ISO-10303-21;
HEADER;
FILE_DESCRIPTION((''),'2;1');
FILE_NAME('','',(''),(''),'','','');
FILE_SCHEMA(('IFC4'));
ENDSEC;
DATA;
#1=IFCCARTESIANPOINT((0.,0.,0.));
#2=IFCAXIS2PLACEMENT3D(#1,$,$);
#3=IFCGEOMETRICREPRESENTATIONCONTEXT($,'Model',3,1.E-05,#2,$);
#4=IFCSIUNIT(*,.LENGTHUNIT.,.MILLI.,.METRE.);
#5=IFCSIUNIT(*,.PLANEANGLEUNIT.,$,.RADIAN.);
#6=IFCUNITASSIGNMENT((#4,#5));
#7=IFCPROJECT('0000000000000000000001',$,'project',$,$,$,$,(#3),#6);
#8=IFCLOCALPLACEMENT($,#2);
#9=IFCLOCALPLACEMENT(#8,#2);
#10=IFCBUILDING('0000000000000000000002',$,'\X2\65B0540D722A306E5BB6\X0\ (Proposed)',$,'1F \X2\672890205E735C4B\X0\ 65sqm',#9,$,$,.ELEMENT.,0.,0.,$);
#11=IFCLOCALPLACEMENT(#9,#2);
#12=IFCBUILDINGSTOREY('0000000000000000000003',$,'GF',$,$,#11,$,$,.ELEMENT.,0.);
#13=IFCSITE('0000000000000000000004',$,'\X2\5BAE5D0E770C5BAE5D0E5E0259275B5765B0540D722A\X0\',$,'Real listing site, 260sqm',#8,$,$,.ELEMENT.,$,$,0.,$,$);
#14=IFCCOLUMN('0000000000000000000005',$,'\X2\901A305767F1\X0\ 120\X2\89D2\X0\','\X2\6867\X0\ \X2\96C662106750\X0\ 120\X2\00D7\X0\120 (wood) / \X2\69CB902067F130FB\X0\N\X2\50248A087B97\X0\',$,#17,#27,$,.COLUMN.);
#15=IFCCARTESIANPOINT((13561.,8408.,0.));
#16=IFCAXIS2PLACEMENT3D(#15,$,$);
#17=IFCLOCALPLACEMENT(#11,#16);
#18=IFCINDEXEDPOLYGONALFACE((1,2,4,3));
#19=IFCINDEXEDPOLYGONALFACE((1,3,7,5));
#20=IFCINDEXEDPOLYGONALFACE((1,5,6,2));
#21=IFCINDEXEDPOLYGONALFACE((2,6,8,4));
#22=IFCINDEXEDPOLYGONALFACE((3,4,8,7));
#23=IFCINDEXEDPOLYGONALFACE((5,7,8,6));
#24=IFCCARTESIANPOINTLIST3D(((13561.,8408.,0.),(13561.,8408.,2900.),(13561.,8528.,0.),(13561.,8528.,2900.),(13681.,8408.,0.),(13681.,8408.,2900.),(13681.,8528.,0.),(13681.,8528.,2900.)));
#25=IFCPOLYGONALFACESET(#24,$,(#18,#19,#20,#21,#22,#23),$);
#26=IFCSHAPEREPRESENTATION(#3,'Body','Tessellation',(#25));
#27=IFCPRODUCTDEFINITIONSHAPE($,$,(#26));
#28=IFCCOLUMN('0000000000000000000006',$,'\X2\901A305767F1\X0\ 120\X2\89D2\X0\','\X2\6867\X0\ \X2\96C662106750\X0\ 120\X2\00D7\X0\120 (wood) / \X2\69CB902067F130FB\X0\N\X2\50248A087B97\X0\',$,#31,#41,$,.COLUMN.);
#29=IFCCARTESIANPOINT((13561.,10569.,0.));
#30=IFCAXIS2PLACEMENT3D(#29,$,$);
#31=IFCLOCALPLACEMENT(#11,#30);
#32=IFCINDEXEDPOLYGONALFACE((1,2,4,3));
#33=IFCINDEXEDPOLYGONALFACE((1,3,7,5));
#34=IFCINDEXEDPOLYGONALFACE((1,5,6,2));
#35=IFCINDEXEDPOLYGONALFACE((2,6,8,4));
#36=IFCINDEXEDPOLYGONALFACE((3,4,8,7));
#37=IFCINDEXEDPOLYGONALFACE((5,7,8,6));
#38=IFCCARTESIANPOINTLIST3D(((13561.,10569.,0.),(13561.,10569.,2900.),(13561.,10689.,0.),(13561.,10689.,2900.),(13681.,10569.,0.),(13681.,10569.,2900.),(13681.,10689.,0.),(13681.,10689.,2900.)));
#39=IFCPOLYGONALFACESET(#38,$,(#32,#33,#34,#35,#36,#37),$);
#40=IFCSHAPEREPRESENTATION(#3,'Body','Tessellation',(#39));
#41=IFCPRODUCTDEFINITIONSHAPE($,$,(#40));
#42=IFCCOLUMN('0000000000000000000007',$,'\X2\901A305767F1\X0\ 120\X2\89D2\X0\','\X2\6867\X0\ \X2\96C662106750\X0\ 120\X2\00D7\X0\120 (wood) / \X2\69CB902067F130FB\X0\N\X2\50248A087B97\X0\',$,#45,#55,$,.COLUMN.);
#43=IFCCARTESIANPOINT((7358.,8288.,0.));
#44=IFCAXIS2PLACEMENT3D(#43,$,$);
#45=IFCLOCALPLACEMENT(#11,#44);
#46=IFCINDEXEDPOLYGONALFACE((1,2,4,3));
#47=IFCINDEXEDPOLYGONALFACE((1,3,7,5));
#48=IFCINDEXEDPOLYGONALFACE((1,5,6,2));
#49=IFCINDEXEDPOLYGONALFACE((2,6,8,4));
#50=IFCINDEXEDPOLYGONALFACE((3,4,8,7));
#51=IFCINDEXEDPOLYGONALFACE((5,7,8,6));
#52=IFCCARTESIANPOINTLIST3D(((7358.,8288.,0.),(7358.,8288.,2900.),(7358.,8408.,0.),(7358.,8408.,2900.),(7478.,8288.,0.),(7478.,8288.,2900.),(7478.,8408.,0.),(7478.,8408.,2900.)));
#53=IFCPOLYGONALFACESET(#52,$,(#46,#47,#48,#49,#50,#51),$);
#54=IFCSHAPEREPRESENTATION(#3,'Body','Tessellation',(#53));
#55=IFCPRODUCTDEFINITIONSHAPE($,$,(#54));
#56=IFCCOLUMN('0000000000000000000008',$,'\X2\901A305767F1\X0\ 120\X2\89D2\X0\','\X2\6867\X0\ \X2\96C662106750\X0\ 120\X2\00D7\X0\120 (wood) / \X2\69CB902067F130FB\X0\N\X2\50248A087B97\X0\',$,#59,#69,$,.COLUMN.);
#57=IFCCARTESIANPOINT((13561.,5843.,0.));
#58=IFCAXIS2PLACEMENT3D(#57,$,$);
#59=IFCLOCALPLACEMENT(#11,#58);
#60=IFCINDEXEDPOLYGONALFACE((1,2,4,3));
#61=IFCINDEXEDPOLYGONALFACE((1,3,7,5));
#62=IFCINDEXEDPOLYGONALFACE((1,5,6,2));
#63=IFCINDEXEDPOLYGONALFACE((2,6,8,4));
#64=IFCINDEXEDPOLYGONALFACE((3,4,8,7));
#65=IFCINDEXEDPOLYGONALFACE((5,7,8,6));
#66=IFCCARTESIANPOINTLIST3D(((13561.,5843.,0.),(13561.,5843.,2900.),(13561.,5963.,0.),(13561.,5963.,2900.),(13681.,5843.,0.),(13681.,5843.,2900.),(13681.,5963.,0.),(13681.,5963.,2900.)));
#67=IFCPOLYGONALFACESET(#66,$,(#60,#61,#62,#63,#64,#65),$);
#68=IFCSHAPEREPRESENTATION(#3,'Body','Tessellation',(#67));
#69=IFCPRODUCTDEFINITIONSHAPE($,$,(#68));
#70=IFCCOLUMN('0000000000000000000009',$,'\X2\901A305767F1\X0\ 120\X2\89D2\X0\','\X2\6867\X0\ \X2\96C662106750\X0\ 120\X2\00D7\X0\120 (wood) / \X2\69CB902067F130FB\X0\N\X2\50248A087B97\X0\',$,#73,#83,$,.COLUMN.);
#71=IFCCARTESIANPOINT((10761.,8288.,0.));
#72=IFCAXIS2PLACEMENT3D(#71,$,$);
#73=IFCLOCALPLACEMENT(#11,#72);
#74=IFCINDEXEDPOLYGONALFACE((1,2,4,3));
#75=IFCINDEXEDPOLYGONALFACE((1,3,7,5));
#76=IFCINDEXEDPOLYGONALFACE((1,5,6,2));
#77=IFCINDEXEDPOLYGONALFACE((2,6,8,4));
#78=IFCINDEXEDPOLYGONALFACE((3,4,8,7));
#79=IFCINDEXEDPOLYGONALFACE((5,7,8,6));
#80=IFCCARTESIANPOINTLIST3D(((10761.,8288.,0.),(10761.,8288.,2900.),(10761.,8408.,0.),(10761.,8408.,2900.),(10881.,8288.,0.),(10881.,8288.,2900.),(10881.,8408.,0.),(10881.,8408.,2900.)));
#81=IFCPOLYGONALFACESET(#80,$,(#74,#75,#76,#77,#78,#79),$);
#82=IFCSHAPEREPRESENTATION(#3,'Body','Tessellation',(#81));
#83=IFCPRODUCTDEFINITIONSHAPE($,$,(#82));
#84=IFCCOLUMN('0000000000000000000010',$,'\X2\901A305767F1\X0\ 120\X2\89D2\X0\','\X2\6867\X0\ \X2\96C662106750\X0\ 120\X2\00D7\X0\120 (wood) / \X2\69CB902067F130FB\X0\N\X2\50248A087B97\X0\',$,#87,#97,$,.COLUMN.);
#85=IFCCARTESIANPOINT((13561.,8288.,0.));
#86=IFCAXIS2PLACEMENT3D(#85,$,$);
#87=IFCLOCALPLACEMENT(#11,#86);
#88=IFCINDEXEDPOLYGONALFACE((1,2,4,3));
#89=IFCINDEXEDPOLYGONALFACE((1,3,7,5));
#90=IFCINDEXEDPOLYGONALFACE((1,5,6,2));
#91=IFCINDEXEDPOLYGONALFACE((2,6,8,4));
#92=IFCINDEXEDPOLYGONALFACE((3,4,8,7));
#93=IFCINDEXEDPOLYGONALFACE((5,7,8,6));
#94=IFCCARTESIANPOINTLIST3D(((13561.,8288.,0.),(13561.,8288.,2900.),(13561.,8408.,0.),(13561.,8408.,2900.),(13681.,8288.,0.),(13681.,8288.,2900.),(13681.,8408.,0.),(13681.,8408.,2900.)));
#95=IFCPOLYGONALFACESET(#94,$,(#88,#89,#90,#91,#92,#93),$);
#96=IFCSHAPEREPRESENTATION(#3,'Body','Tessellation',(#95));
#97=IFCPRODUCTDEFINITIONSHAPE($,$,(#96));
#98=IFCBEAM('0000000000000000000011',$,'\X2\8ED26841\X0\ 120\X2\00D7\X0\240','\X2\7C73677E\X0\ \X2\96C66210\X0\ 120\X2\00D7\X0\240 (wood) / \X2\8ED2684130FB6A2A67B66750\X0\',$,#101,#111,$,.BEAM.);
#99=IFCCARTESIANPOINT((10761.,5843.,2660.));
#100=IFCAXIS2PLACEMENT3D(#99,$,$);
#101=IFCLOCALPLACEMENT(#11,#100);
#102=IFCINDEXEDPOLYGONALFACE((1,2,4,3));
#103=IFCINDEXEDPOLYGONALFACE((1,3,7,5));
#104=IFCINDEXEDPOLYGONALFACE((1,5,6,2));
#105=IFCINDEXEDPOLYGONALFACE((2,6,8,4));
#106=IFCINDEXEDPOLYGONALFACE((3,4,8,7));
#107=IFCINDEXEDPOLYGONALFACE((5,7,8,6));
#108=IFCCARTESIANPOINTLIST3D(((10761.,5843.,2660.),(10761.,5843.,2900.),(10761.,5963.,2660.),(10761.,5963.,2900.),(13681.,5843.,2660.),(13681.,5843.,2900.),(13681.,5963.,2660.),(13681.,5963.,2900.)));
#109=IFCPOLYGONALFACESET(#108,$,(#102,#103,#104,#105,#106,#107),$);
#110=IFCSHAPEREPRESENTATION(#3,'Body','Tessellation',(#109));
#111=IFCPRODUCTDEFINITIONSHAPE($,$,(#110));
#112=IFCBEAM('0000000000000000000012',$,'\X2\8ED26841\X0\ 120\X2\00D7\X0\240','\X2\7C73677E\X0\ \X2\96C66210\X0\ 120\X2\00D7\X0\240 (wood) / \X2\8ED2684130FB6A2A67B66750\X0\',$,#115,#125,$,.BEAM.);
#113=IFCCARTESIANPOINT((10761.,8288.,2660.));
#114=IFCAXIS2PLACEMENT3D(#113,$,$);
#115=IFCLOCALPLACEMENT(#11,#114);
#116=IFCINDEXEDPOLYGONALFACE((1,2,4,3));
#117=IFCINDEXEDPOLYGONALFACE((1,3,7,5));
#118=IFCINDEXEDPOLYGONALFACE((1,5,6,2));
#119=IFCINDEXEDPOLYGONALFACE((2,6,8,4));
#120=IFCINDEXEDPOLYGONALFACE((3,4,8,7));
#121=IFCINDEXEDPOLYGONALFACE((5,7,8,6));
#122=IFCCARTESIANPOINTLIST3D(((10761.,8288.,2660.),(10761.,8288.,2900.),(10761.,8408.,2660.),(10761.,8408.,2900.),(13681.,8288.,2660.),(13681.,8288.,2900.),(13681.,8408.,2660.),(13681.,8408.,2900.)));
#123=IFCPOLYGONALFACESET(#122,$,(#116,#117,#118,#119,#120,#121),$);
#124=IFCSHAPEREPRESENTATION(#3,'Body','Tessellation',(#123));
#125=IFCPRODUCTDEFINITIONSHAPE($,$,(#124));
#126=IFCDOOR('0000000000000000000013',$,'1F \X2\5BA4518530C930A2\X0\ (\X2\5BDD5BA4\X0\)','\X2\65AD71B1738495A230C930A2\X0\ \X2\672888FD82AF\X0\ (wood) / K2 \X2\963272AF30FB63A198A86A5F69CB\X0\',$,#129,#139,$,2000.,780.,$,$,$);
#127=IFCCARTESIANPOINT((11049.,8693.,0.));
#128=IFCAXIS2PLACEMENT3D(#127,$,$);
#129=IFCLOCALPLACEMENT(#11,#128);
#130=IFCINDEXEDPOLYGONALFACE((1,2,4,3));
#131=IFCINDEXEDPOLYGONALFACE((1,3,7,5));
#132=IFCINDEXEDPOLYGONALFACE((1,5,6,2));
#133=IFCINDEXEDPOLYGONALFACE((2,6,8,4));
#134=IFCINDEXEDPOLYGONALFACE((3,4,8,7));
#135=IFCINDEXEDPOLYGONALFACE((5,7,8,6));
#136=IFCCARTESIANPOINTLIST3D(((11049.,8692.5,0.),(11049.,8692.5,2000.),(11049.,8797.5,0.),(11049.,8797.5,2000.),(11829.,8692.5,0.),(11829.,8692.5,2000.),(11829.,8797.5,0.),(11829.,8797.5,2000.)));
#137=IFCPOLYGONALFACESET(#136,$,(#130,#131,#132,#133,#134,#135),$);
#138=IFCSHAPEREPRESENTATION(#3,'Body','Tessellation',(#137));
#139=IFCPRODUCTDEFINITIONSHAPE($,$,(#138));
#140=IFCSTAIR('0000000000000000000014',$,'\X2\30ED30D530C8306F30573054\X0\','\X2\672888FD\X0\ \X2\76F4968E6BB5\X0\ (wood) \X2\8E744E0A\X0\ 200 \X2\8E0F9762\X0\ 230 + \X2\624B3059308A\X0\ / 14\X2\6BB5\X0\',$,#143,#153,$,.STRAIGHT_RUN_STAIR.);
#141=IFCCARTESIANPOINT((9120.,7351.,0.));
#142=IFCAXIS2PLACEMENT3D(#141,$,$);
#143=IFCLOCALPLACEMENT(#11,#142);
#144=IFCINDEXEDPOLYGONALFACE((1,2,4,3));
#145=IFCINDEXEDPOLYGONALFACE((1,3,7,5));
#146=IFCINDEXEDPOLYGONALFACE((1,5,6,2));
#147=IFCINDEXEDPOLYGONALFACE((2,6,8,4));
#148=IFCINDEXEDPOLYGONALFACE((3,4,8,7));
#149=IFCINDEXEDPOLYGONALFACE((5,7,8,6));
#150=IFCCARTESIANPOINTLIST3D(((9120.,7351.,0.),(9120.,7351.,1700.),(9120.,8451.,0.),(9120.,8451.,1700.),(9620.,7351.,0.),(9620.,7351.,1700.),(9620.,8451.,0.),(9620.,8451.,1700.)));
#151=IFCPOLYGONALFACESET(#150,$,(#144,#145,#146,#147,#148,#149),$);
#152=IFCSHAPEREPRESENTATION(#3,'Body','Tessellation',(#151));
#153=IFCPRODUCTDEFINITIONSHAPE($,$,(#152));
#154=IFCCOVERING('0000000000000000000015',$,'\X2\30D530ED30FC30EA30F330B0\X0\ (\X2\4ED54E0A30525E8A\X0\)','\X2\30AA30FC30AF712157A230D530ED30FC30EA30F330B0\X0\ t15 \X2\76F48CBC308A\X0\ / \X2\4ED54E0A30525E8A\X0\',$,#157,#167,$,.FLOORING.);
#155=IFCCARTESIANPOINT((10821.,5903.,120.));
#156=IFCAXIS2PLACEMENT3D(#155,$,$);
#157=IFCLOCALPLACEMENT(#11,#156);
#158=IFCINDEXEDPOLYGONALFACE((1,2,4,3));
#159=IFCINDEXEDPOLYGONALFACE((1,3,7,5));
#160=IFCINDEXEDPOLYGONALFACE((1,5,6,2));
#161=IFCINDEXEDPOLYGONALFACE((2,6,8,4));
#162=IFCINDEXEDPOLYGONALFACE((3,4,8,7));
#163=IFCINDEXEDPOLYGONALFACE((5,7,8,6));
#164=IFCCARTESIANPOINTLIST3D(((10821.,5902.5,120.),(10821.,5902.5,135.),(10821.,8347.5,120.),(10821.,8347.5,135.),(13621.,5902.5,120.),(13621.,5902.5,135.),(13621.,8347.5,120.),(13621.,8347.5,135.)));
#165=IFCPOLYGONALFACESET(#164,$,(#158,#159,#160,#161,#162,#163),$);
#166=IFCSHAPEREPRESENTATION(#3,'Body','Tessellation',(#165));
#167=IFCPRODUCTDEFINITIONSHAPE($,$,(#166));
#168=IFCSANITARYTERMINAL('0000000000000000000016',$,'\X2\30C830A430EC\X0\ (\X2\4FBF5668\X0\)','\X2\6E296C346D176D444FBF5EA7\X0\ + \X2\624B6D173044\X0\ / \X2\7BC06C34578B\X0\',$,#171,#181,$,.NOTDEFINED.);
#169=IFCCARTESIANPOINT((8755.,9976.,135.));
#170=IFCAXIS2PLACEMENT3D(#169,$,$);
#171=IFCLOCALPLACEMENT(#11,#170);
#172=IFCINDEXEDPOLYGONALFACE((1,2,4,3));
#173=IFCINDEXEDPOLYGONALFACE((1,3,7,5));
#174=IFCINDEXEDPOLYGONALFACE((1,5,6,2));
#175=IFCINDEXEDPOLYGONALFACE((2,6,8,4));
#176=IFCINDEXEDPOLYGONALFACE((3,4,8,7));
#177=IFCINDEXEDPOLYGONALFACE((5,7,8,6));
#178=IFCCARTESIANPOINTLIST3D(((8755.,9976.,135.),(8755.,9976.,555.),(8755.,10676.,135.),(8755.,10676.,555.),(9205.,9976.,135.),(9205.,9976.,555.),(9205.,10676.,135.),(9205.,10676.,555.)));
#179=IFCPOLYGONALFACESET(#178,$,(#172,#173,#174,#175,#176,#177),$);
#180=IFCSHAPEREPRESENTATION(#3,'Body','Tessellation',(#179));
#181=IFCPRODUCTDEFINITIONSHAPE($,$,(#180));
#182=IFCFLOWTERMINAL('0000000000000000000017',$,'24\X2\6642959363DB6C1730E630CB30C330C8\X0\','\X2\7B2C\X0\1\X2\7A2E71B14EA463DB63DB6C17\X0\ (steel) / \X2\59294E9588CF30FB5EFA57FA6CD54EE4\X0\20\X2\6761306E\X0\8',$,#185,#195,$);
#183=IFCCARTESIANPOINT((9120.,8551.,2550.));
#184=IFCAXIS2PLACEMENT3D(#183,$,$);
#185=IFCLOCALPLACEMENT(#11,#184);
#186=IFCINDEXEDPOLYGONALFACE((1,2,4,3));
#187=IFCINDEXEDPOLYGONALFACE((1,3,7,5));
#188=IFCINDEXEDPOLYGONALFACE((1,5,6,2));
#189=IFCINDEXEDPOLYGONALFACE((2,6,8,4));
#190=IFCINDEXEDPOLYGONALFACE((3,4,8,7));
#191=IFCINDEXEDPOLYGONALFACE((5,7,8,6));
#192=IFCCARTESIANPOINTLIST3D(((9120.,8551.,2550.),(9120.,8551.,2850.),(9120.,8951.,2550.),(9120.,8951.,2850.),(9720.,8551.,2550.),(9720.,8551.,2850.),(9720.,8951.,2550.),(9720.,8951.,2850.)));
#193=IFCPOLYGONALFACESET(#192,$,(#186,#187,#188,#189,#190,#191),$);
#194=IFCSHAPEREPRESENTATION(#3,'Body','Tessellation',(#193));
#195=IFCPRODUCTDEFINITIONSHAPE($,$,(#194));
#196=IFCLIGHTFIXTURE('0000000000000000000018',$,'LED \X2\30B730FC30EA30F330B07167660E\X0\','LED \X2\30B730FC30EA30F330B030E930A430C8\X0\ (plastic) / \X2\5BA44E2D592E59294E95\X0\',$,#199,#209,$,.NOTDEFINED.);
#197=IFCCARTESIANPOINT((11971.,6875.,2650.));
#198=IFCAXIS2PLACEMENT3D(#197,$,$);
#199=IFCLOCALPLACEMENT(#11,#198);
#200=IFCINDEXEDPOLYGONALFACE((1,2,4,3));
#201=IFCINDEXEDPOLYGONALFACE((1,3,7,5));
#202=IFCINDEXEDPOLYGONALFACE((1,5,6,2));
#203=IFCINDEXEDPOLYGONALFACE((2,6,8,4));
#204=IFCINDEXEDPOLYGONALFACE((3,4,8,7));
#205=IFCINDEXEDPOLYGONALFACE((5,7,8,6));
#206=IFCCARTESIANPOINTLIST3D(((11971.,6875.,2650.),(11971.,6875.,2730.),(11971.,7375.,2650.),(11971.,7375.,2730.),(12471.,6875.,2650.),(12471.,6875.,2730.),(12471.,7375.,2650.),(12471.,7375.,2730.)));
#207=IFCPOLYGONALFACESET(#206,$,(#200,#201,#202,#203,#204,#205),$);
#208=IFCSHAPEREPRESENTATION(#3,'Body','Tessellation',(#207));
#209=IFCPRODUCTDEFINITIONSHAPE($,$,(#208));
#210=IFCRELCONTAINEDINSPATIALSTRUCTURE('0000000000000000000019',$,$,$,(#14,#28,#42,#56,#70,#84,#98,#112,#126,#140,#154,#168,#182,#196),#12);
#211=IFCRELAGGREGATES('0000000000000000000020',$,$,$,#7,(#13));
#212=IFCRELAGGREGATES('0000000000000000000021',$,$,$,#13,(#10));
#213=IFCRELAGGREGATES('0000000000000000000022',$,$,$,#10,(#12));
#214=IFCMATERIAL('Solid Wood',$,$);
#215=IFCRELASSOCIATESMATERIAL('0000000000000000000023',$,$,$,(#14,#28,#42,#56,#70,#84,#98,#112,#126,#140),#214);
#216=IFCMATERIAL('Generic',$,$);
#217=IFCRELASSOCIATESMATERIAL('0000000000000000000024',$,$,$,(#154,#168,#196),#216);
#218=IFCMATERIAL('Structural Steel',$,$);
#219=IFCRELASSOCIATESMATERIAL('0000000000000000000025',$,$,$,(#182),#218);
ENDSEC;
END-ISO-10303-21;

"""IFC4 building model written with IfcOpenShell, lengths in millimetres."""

from ifc_helpers import new_model, si_unit, frame, frame_2d, origin, place, context, project, spatial, rectangle, extrude, material, element, save


model = new_model("IFC4")

# Units and contexts
model_context = context("Model", 3, precision=1e-05, world=origin())
ifc_project = project(units=[si_unit("LENGTHUNIT", "METRE", prefix="MILLI"), si_unit("PLANEANGLEUNIT", "RADIAN")], contexts=[model_context])

# Site, building, storey
site_placement = place(None, origin())
site = spatial("IfcSite", under=ifc_project, at=site_placement, Name="宮崎県宮崎市大字新名爪", ObjectType="Real listing site, 260sqm", CompositionType="ELEMENT", RefElevation=0.0)
building_placement = place(site_placement, origin())
building = spatial("IfcBuilding", under=site, at=building_placement, Name="新名爪の家 (Proposed)", ObjectType="1F 木造平屋 65sqm", CompositionType="ELEMENT", ElevationOfRefHeight=0.0, ElevationOfTerrain=0.0)
storey_placement = place(building_placement, origin())
storey = spatial("IfcBuildingStorey", under=building, at=storey_placement, Name="GF", CompositionType="ELEMENT", Elevation=0.0)

# Columns
ifc_material_1 = material(Name="Solid Wood")
column_1_placement = place(storey_placement, frame((13561.0, 8408.0, 0.0)))
element("IfcColumn", 1, at=column_1_placement, inside=storey, material=ifc_material_1, Name="通し柱 120角", Description="桧 集成材 120×120 (wood) / 構造柱・N値計算", PredefinedType="COLUMN", context=model_context, shape_type="SweptSolid", body=[
    extrude(rectangle(XDim=120.0, YDim=120.0, at=frame_2d((60.0, 60.0))), frame((13561.0, 8408.0, 0.0)), (0.0, 0.0, 1.0), 2900.0),
])
column_2_placement = place(storey_placement, frame((13561.0, 10569.0, 0.0)))
element("IfcColumn", 2, at=column_2_placement, inside=storey, material=ifc_material_1, Name="通し柱 120角", Description="桧 集成材 120×120 (wood) / 構造柱・N値計算", PredefinedType="COLUMN", context=model_context, shape_type="SweptSolid", body=[
    extrude(rectangle(XDim=120.0, YDim=120.0, at=frame_2d((60.0, 60.0))), frame((13561.0, 10569.0, 0.0)), (0.0, 0.0, 1.0), 2900.0),
])
column_3_placement = place(storey_placement, frame((7358.0, 8288.0, 0.0)))
element("IfcColumn", 3, at=column_3_placement, inside=storey, material=ifc_material_1, Name="通し柱 120角", Description="桧 集成材 120×120 (wood) / 構造柱・N値計算", PredefinedType="COLUMN", context=model_context, shape_type="SweptSolid", body=[
    extrude(rectangle(XDim=120.0, YDim=120.0, at=frame_2d((60.0, 60.0))), frame((7358.0, 8288.0, 0.0)), (0.0, 0.0, 1.0), 2900.0),
])
column_4_placement = place(storey_placement, frame((13561.0, 5843.0, 0.0)))
element("IfcColumn", 4, at=column_4_placement, inside=storey, material=ifc_material_1, Name="通し柱 120角", Description="桧 集成材 120×120 (wood) / 構造柱・N値計算", PredefinedType="COLUMN", context=model_context, shape_type="SweptSolid", body=[
    extrude(rectangle(XDim=120.0, YDim=120.0, at=frame_2d((60.0, 60.0))), frame((13561.0, 5843.0, 0.0)), (0.0, 0.0, 1.0), 2900.0),
])
column_5_placement = place(storey_placement, frame((10761.0, 8288.0, 0.0)))
element("IfcColumn", 5, at=column_5_placement, inside=storey, material=ifc_material_1, Name="通し柱 120角", Description="桧 集成材 120×120 (wood) / 構造柱・N値計算", PredefinedType="COLUMN", context=model_context, shape_type="SweptSolid", body=[
    extrude(rectangle(XDim=120.0, YDim=120.0, at=frame_2d((60.0, 60.0))), frame((10761.0, 8288.0, 0.0)), (0.0, 0.0, 1.0), 2900.0),
])
column_6_placement = place(storey_placement, frame((13561.0, 8288.0, 0.0)))
element("IfcColumn", 6, at=column_6_placement, inside=storey, material=ifc_material_1, Name="通し柱 120角", Description="桧 集成材 120×120 (wood) / 構造柱・N値計算", PredefinedType="COLUMN", context=model_context, shape_type="SweptSolid", body=[
    extrude(rectangle(XDim=120.0, YDim=120.0, at=frame_2d((60.0, 60.0))), frame((13561.0, 8288.0, 0.0)), (0.0, 0.0, 1.0), 2900.0),
])

# Beams
beam_1_placement = place(storey_placement, frame((10761.0, 5843.0, 2660.0)))
element("IfcBeam", 7, at=beam_1_placement, inside=storey, material=ifc_material_1, Name="軒桁 120×240", Description="米松 集成 120×240 (wood) / 軒桁・横架材", PredefinedType="BEAM", context=model_context, shape_type="SweptSolid", body=[
    extrude(rectangle(XDim=2920.0, YDim=120.0, at=frame_2d((1460.0, 60.0))), frame((10761.0, 5843.0, 2660.0)), (0.0, 0.0, 1.0), 240.0),
])
beam_2_placement = place(storey_placement, frame((10761.0, 8288.0, 2660.0)))
element("IfcBeam", 8, at=beam_2_placement, inside=storey, material=ifc_material_1, Name="軒桁 120×240", Description="米松 集成 120×240 (wood) / 軒桁・横架材", PredefinedType="BEAM", context=model_context, shape_type="SweptSolid", body=[
    extrude(rectangle(XDim=2920.0, YDim=120.0, at=frame_2d((1460.0, 60.0))), frame((10761.0, 8288.0, 2660.0)), (0.0, 0.0, 1.0), 240.0),
])

# Door
door_placement = place(storey_placement, frame((11049.0, 8693.0, 0.0)))
element("IfcDoor", 9, at=door_placement, inside=storey, material=ifc_material_1, Name="1F 室内ドア (寝室)", Description="断熱玄関ドア 木製芯 (wood) / K2 防犯・採風機構", OverallHeight=2000.0, OverallWidth=780.0, context=model_context, shape_type="SweptSolid", body=[
    extrude(rectangle(XDim=780.0, YDim=105.0, at=frame_2d((390.0, 52.0))), frame((11049.0, 8693.0, 0.0)), (0.0, 0.0, 1.0), 2000.0),
])

# Stair
stair_placement = place(storey_placement, frame((9120.0, 7351.0, 0.0)))
element("IfcStair", 10, at=stair_placement, inside=storey, material=ifc_material_1, Name="ロフトはしご", Description="木製 直階段 (wood) 蹴上 200 踏面 230 + 手すり / 14段", PredefinedType="STRAIGHT_RUN_STAIR", context=model_context, shape_type="SweptSolid", body=[
    extrude(rectangle(XDim=500.0, YDim=1100.0, at=frame_2d((250.0, 550.0))), frame((9120.0, 7351.0, 0.0)), (0.0, 0.0, 1.0), 1700.0),
])

# Covering
ifc_material_2 = material(Name="Generic")
covering_placement = place(storey_placement, frame((10821.0, 5903.0, 120.0)))
element("IfcCovering", 11, at=covering_placement, inside=storey, material=ifc_material_2, Name="フローリング (仕上げ床)", Description="オーク無垢フローリング t15 直貼り / 仕上げ床", PredefinedType="FLOORING", context=model_context, shape_type="SweptSolid", body=[
    extrude(rectangle(XDim=2800.0, YDim=2445.0, at=frame_2d((1400.0, 1222.0))), frame((10821.0, 5903.0, 120.0)), (0.0, 0.0, 1.0), 15.0),
])

# Sanitary terminal
sanitary_terminal_placement = place(storey_placement, frame((8755.0, 9976.0, 135.0)))
element("IfcSanitaryTerminal", 12, at=sanitary_terminal_placement, inside=storey, material=ifc_material_2, Name="トイレ (便器)", Description="温水洗浄便座 + 手洗い / 節水型", PredefinedType="NOTDEFINED", context=model_context, shape_type="SweptSolid", body=[
    extrude(rectangle(XDim=450.0, YDim=700.0, at=frame_2d((225.0, 350.0))), frame((8755.0, 9976.0, 135.0)), (0.0, 0.0, 1.0), 420.0),
])

# Flow terminal
ifc_material_3 = material(Name="Structural Steel")
flow_terminal_placement = place(storey_placement, frame((9120.0, 8551.0, 2550.0)))
element("IfcFlowTerminal", 13, at=flow_terminal_placement, inside=storey, material=ifc_material_3, Name="24時間換気ユニット", Description="第1種熱交換換気 (steel) / 天井裏・建基法令20条の8", context=model_context, shape_type="SweptSolid", body=[
    extrude(rectangle(XDim=600.0, YDim=400.0, at=frame_2d((300.0, 200.0))), frame((9120.0, 8551.0, 2550.0)), (0.0, 0.0, 1.0), 300.0),
])

# Light fixture
light_fixture_placement = place(storey_placement, frame((11971.0, 6875.0, 2650.0)))
element("IfcLightFixture", 14, at=light_fixture_placement, inside=storey, material=ifc_material_2, Name="LED シーリング照明", Description="LED シーリングライト (plastic) / 室中央天井", PredefinedType="NOTDEFINED", context=model_context, shape_type="SweptSolid", body=[
    extrude(rectangle(XDim=500.0, YDim=500.0, at=frame_2d((250.0, 250.0))), frame((11971.0, 6875.0, 2650.0)), (0.0, 0.0, 1.0), 80.0),
])

save(model, "model.ifc")
